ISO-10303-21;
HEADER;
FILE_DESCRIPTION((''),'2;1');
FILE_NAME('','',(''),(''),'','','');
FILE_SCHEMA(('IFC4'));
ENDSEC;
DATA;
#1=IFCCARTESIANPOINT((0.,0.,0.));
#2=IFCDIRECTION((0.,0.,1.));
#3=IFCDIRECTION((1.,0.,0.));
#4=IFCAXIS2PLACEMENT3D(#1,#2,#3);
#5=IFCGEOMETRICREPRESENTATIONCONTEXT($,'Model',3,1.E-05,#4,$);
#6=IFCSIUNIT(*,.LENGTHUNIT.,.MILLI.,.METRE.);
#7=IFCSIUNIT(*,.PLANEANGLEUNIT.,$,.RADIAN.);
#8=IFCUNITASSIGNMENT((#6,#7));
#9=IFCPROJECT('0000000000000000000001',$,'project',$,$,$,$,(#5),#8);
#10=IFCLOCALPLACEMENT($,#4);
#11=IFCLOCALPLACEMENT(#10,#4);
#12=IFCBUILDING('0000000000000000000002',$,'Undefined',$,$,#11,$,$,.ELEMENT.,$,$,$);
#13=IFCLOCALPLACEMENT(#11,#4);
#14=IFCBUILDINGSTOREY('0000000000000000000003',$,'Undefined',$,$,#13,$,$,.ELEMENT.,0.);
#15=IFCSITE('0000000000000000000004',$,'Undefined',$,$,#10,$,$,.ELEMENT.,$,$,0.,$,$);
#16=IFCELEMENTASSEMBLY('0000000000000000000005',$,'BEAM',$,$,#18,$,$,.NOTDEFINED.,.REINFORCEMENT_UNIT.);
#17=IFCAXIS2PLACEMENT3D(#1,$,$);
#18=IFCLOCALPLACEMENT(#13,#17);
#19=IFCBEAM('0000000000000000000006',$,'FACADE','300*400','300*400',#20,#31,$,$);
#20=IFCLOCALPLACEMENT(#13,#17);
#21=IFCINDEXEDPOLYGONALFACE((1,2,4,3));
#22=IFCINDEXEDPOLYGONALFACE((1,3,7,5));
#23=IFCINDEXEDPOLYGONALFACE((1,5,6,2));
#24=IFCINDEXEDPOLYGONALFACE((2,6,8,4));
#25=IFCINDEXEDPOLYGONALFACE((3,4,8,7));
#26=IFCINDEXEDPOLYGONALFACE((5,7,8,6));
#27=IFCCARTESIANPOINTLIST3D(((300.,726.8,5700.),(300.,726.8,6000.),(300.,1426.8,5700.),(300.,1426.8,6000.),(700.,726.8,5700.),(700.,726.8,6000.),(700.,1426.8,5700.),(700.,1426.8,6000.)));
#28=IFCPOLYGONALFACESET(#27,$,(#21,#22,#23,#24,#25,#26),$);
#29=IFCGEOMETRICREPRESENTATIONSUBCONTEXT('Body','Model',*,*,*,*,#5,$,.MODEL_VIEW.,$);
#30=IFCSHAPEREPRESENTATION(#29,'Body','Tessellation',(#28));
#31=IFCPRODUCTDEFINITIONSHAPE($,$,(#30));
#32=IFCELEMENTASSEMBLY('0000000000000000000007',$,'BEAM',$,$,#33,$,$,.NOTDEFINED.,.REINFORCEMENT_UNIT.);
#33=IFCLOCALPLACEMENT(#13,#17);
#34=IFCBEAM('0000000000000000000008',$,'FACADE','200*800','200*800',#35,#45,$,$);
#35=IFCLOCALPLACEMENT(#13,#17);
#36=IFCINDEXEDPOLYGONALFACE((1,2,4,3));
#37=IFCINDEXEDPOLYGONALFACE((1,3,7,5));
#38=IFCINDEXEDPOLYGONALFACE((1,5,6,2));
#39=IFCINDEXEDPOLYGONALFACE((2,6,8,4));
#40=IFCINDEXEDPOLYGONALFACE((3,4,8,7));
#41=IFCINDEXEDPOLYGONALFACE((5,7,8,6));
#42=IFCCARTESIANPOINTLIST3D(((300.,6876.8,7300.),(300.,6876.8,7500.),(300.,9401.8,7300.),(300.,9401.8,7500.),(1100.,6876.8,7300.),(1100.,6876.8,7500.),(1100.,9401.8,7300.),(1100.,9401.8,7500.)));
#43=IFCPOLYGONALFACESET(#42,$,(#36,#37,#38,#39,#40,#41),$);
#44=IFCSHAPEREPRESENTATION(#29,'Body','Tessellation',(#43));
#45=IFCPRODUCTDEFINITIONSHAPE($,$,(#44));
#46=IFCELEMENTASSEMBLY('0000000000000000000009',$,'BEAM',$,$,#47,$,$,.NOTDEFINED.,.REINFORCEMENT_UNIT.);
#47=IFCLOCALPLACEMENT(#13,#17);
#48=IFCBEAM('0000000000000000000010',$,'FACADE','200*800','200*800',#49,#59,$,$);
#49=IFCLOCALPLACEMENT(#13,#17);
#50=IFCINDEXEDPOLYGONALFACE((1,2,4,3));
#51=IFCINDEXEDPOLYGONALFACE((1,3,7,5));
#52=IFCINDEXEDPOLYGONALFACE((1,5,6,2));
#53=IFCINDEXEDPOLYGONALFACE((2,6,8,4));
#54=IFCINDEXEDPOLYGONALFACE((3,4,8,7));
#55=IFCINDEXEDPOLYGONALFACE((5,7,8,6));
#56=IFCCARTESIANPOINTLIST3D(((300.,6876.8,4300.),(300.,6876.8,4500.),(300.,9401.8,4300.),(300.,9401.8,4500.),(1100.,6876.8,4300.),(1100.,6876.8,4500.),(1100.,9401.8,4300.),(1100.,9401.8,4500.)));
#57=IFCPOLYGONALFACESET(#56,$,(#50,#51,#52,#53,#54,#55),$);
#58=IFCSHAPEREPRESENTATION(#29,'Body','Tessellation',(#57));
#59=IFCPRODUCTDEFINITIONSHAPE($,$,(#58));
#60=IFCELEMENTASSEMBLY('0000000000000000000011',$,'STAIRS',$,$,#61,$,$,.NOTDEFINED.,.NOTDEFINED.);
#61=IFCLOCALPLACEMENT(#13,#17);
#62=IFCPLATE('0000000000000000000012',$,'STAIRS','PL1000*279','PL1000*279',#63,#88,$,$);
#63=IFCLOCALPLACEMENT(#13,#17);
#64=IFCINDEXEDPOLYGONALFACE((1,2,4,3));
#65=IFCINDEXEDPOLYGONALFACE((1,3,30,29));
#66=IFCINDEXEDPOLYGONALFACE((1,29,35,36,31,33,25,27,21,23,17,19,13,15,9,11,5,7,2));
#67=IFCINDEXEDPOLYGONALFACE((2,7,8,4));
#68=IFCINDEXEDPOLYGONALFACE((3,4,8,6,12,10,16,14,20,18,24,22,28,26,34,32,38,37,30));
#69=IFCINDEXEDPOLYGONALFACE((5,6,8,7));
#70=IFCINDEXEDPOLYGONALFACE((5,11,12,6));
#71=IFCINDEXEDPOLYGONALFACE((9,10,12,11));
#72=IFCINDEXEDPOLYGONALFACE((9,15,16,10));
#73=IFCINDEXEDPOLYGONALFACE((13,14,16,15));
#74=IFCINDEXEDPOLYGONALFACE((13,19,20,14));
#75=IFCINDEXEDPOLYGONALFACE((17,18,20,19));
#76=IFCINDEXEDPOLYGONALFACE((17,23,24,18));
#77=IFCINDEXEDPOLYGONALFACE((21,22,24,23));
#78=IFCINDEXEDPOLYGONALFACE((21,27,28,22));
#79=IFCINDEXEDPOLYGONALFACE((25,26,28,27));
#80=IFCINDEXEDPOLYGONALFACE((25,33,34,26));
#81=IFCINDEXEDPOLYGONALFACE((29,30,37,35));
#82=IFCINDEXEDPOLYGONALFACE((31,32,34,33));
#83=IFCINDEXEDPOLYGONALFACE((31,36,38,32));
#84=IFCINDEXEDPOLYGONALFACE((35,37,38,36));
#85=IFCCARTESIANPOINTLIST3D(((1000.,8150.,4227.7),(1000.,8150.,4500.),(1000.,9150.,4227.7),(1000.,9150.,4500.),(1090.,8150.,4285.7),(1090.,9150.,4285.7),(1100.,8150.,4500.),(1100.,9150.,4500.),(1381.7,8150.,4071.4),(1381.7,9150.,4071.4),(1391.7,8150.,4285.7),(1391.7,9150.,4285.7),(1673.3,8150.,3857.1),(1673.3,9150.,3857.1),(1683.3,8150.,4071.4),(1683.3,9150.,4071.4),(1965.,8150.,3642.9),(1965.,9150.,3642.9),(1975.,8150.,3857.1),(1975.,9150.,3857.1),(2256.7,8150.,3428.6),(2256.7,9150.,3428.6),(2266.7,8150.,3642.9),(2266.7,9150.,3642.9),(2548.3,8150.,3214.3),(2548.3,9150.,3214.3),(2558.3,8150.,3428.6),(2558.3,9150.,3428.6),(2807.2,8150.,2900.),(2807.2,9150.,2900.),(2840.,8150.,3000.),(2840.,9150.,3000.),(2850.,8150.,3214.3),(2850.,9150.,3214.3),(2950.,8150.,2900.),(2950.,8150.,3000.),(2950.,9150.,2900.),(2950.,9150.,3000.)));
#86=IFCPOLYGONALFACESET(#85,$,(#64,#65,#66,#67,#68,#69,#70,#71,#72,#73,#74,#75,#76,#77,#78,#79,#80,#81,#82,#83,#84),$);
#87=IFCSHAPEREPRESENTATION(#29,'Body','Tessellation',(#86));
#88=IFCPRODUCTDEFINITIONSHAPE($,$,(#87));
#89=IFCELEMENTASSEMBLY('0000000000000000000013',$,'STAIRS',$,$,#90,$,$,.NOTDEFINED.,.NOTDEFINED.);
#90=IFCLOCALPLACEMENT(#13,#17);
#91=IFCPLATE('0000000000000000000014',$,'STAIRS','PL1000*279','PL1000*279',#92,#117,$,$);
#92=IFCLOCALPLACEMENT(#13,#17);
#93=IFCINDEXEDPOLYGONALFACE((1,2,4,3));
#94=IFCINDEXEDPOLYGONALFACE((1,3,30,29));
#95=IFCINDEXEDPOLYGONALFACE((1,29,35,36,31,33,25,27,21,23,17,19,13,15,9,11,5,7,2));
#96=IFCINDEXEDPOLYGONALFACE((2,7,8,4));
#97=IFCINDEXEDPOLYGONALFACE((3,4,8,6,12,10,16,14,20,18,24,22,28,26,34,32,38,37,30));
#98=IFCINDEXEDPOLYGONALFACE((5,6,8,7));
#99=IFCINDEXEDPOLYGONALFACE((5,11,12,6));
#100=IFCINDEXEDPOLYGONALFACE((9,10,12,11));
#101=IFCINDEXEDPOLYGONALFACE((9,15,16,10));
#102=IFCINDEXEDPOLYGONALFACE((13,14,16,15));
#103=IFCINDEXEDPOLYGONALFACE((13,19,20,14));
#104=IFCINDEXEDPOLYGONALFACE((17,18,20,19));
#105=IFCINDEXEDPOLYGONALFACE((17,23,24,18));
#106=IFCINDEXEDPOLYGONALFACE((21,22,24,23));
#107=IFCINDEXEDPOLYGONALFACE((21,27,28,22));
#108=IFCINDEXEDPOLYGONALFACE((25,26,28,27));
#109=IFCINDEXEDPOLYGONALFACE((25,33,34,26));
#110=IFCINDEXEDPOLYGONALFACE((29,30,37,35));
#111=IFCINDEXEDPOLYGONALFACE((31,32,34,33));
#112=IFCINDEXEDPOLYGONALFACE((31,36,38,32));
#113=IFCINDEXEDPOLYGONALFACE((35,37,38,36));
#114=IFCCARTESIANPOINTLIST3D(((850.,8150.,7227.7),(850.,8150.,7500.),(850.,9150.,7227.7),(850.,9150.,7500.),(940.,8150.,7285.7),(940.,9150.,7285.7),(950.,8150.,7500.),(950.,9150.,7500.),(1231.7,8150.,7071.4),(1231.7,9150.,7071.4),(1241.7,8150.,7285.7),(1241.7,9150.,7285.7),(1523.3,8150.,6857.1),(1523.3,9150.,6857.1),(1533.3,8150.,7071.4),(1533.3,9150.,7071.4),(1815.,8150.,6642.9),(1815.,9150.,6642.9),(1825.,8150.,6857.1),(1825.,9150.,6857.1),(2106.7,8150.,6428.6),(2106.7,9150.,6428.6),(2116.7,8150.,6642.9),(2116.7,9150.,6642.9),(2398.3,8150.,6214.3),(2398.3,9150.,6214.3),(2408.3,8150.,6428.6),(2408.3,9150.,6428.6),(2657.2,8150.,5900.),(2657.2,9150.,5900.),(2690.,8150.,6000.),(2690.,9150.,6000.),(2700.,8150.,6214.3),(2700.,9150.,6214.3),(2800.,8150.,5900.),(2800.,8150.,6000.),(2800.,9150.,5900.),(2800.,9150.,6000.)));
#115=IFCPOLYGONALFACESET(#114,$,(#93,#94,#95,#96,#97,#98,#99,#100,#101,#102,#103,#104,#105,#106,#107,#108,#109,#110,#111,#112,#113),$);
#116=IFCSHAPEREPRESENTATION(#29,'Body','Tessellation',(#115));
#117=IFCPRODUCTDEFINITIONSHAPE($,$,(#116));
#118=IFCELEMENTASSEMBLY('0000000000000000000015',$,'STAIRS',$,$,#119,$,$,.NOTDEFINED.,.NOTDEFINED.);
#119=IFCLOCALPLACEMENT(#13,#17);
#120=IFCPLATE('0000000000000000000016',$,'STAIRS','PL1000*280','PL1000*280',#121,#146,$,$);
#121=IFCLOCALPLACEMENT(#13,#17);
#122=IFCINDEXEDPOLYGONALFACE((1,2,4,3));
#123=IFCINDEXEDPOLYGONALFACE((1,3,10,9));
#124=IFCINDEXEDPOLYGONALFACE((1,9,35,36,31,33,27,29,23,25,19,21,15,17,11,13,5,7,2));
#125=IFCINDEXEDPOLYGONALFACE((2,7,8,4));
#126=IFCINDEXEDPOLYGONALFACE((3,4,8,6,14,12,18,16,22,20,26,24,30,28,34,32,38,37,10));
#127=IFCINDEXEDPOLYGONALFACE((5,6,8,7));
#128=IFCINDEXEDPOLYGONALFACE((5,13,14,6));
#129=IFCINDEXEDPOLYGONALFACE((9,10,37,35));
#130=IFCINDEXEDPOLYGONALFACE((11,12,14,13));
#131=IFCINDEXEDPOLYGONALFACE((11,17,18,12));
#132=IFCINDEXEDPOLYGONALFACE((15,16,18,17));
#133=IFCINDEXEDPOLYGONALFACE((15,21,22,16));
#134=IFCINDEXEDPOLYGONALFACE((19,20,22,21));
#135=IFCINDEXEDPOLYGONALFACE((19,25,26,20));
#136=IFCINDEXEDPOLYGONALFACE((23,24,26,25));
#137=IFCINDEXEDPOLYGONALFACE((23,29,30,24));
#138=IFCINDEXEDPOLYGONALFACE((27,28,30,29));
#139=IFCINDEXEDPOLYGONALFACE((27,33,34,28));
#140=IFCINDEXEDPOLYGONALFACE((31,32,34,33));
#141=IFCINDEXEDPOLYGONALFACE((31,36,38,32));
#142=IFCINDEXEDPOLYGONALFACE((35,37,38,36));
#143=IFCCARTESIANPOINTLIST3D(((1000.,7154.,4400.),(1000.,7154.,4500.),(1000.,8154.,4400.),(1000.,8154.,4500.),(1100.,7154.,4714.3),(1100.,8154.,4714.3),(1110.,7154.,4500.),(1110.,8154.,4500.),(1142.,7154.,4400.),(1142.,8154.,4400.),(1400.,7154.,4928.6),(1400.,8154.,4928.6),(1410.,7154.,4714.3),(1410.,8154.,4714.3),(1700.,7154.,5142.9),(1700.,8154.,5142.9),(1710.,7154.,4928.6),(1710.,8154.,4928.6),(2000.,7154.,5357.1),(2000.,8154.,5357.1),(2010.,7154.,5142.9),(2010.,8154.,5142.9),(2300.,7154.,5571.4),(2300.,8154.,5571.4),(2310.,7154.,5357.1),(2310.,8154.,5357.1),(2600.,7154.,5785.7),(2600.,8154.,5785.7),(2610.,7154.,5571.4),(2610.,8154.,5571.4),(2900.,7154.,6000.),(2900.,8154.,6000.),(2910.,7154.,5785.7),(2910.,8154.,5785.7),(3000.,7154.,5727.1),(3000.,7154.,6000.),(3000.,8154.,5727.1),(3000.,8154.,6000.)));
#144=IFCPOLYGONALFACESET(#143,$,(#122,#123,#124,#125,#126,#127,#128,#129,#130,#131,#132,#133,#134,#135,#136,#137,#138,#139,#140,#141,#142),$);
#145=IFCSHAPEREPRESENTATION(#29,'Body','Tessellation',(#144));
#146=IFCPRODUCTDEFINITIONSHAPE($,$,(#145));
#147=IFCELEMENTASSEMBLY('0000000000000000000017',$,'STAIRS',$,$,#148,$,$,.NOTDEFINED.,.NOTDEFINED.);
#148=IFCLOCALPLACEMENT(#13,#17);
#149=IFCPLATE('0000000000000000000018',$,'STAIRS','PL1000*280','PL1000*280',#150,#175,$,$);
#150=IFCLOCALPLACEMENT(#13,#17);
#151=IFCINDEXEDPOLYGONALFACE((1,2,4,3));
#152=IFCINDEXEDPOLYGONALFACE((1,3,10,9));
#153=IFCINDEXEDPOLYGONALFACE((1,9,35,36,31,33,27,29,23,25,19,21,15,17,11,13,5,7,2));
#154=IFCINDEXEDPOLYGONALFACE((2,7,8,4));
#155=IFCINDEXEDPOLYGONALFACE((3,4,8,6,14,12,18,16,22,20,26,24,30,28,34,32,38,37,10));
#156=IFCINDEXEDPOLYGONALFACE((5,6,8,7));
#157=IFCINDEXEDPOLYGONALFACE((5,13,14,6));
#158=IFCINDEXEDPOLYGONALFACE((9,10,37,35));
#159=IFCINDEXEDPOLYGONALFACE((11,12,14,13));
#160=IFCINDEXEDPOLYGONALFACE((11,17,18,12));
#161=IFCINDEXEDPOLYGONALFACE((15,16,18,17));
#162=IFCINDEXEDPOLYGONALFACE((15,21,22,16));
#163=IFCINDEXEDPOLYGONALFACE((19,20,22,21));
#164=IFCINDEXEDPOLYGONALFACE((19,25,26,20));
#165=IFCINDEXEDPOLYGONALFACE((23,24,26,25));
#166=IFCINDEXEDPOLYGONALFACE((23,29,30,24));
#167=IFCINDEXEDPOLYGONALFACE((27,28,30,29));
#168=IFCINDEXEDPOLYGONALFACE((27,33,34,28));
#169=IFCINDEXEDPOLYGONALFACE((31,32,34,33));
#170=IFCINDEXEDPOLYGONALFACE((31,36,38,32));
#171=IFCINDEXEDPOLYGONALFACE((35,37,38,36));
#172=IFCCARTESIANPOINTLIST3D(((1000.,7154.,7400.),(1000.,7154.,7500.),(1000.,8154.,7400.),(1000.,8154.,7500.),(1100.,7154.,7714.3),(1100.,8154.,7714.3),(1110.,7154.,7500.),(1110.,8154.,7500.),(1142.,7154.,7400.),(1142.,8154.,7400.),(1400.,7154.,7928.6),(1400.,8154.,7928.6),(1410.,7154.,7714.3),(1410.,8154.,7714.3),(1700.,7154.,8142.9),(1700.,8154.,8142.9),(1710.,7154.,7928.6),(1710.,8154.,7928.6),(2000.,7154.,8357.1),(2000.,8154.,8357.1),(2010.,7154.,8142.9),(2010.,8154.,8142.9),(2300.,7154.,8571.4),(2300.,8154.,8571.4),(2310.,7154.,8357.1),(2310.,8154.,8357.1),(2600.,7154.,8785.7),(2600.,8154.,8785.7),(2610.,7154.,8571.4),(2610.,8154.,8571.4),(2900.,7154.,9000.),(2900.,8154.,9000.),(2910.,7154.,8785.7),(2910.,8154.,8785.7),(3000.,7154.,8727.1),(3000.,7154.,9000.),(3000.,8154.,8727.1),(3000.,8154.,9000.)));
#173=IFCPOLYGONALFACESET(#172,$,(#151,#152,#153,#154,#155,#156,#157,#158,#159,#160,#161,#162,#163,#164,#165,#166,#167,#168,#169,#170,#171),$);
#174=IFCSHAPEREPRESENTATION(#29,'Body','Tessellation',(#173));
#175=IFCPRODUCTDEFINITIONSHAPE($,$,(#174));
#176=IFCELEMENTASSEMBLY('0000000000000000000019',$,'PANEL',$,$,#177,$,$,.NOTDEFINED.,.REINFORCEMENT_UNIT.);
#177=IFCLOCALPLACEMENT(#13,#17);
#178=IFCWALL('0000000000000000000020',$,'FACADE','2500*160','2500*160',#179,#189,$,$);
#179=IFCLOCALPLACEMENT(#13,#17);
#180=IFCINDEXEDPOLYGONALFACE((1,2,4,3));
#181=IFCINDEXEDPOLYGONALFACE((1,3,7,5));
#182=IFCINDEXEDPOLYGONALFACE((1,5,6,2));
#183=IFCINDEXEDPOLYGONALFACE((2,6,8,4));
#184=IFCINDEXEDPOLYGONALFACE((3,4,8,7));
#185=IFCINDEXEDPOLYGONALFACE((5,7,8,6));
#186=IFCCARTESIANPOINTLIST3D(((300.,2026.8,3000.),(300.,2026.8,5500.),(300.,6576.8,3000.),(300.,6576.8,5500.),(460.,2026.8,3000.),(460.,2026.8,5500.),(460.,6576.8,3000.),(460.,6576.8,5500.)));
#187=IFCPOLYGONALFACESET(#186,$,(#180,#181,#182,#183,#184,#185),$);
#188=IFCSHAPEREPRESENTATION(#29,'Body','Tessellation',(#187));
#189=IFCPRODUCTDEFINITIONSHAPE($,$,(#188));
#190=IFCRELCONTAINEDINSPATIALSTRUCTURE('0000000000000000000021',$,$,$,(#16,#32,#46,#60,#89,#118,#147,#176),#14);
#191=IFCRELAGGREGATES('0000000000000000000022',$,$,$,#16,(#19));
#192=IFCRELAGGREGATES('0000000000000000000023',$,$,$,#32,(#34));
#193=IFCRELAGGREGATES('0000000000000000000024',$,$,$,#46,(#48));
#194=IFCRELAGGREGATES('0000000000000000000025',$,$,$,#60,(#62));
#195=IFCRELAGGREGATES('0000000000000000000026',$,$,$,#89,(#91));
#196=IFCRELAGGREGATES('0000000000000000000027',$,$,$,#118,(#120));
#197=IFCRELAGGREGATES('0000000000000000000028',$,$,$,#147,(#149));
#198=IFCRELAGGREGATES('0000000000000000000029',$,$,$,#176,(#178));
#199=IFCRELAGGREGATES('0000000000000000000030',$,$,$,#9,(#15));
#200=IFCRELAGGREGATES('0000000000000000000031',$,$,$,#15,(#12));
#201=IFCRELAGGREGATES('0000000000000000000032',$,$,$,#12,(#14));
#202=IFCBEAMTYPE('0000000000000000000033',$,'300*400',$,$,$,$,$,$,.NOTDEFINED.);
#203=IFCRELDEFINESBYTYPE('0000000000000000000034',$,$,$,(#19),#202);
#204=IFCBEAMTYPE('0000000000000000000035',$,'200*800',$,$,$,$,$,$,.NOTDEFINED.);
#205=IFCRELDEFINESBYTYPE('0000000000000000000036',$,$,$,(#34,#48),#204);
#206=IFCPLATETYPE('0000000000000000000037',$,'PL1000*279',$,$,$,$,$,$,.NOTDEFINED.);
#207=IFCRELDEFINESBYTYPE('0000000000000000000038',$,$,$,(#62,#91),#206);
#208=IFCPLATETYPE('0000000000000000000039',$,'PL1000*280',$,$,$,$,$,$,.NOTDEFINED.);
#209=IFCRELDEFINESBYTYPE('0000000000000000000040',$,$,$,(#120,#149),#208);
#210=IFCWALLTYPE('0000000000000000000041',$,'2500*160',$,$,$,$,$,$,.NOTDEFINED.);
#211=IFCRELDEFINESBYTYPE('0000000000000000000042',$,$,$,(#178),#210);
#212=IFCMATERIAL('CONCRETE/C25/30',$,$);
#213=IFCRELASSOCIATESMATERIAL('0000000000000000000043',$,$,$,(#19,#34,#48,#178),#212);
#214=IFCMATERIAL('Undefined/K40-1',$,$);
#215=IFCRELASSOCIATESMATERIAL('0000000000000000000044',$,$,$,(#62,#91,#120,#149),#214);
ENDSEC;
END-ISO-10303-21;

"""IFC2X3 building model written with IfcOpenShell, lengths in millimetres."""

from ifc_helpers import new_model, si_unit, frame, frame_2d, origin_with_axes, origin_2d_with_axis, place, context, subcontext, project, spatial, polyline, rectangle, outline, extrude, material, type_object, element, aggregate, save


model = new_model("IFC2X3")

# Units and contexts
model_context = context("Model", 3, precision=1e-05, world=origin_with_axes())
body_context = subcontext(model_context, "Body", "Model", "MODEL_VIEW")
ifc_project = project(units=[si_unit("LENGTHUNIT", "METRE", prefix="MILLI"), si_unit("PLANEANGLEUNIT", "RADIAN")], contexts=[model_context])

# Site, building, storey
site_placement = place(None, origin_with_axes())
site = spatial("IfcSite", under=ifc_project, at=site_placement, Name="Undefined", CompositionType="ELEMENT", RefElevation=0.0)
building_placement = place(site_placement, origin_with_axes())
building = spatial("IfcBuilding", under=site, at=building_placement, Name="Undefined", CompositionType="ELEMENT")
storey_placement = place(building_placement, origin_with_axes())
storey = spatial("IfcBuildingStorey", under=building, at=storey_placement, Name="Undefined", CompositionType="ELEMENT", Elevation=0.0)

# Shared definitions
ifc_material_1 = material(Name="CONCRETE/C25/30")

# Element assemblies, beams
beam_type_1 = type_object("IfcBeamType", Name="300*400", PredefinedType="NOTDEFINED")
assembly_1_placement = place(storey_placement, origin_with_axes())
assembly_1 = element("IfcElementAssembly", 1, at=assembly_1_placement, inside=storey, Name="BEAM", AssemblyPlace="NOTDEFINED", PredefinedType="REINFORCEMENT_UNIT")
beam_1_placement = place(assembly_1_placement, frame((500.0, 1426.8, 5850.0), z_axis=(0.0, 0.0, 1.0), x_axis=(0.0, -1.0, 0.0)))
beam_1 = element("IfcBeam", 2, at=beam_1_placement, type_object=beam_type_1, material=ifc_material_1, Name="FACADE", Description="300*400", ObjectType="300*400", context=body_context, shape_type="SweptSolid", body=[
    extrude(rectangle(XDim=400.0, YDim=300.0, at=origin_2d_with_axis()), frame((700.0, 0.0, 0.0), z_axis=(-1.0, 0.0, 0.0), x_axis=(0.0, -1.0, 0.0)), (0.0, 0.0, 1.0), 700.0),
])
aggregate(assembly_1, [beam_1])
assembly_2_placement = place(storey_placement, origin_with_axes())
assembly_2 = element("IfcElementAssembly", 3, at=assembly_2_placement, inside=storey, Name="BEAM", AssemblyPlace="NOTDEFINED", PredefinedType="REINFORCEMENT_UNIT")
beam_type_2 = type_object("IfcBeamType", Name="200*800", PredefinedType="NOTDEFINED")
beam_2_placement = place(assembly_2_placement, frame((700.0, 9401.8, 7400.0), z_axis=(0.0, 0.0, 1.0), x_axis=(0.0, -1.0, 0.0)))
beam_2 = element("IfcBeam", 4, at=beam_2_placement, type_object=beam_type_2, material=ifc_material_1, Name="FACADE", Description="200*800", ObjectType="200*800", context=body_context, shape_type="SweptSolid", body=[
    extrude(rectangle(XDim=800.0, YDim=200.0, at=origin_2d_with_axis()), frame((2525.0, 0.0, 0.0), z_axis=(-1.0, 0.0, 0.0), x_axis=(0.0, -1.0, 0.0)), (0.0, 0.0, 1.0), 2525.0),
])
aggregate(assembly_2, [beam_2])
assembly_3_placement = place(storey_placement, origin_with_axes())
assembly_3 = element("IfcElementAssembly", 5, at=assembly_3_placement, inside=storey, Name="BEAM", AssemblyPlace="NOTDEFINED", PredefinedType="REINFORCEMENT_UNIT")
beam_3_placement = place(assembly_3_placement, frame((700.0, 9401.8, 4400.0), z_axis=(0.0, 0.0, 1.0), x_axis=(0.0, -1.0, 0.0)))
beam_3 = element("IfcBeam", 6, at=beam_3_placement, type_object=beam_type_2, material=ifc_material_1, Name="FACADE", Description="200*800", ObjectType="200*800", context=body_context, shape_type="SweptSolid", body=[
    extrude(rectangle(XDim=800.0, YDim=200.0, at=origin_2d_with_axis()), frame((2525.0, 0.0, 0.0), z_axis=(-1.0, 0.0, 0.0), x_axis=(0.0, -1.0, 0.0)), (0.0, 0.0, 1.0), 2525.0),
])
aggregate(assembly_3, [beam_3])

# Element assemblies, plates
assembly_4_placement = place(storey_placement, origin_with_axes())
assembly_4 = element("IfcElementAssembly", 7, at=assembly_4_placement, inside=storey, Name="STAIRS", AssemblyPlace="NOTDEFINED", PredefinedType="NOTDEFINED")
ifc_material_2 = material(Name="Undefined/K40-1")
plate_type_1 = type_object("IfcPlateType", Name="PL1000*279", PredefinedType="NOTDEFINED")
plate_1_placement = place(assembly_4_placement, frame((2840.0, 8650.0, 3000.0), z_axis=(0.0, 1.0, 0.0), x_axis=(1.0, 0.0, 0.0)))
plate_1 = element("IfcPlate", 8, at=plate_1_placement, type_object=plate_type_1, material=ifc_material_2, Name="STAIRS", Description="PL1000*279", ObjectType="PL1000*279", context=body_context, shape_type="SweptSolid", body=[
    extrude(outline(polyline([(0.0, 0.0), (110.0, 0.0), (110.0, 100.0), (-32.8, 100.0), (-1840.0, -1227.7), (-1840.0, -1500.0), (-1740.0, -1500.0), (-1750.0, -1285.7), (-1448.3, -1285.7), (-1458.3, -1071.4), (-1156.7, -1071.4), (-1166.7, -857.1), (-865.0, -857.1), (-875.0, -642.9), (-573.3, -642.9), (-583.3, -428.6), (-281.7, -428.6), (-291.7, -214.3), (10.0, -214.3), (0.0, 0.0), (0.0, 0.0)])), frame((0.0, 0.0, -500.0), z_axis=(0.0, 0.0, 1.0), x_axis=(1.0, 0.0, 0.0)), (0.0, 0.0, 1.0), 1000.0),
])
aggregate(assembly_4, [plate_1])
assembly_5_placement = place(storey_placement, origin_with_axes())
assembly_5 = element("IfcElementAssembly", 9, at=assembly_5_placement, inside=storey, Name="STAIRS", AssemblyPlace="NOTDEFINED", PredefinedType="NOTDEFINED")
plate_2_placement = place(assembly_5_placement, frame((2690.0, 8650.0, 6000.0), z_axis=(0.0, 1.0, 0.0), x_axis=(1.0, 0.0, 0.0)))
plate_2 = element("IfcPlate", 10, at=plate_2_placement, type_object=plate_type_1, material=ifc_material_2, Name="STAIRS", Description="PL1000*279", ObjectType="PL1000*279", context=body_context, shape_type="SweptSolid", body=[
    extrude(outline(polyline([(0.0, 0.0), (110.0, 0.0), (110.0, 100.0), (-32.8, 100.0), (-1840.0, -1227.7), (-1840.0, -1500.0), (-1740.0, -1500.0), (-1750.0, -1285.7), (-1448.3, -1285.7), (-1458.3, -1071.4), (-1156.7, -1071.4), (-1166.7, -857.1), (-865.0, -857.1), (-875.0, -642.9), (-573.3, -642.9), (-583.3, -428.6), (-281.7, -428.6), (-291.7, -214.3), (10.0, -214.3), (0.0, 0.0), (0.0, 0.0)])), frame((0.0, 0.0, -500.0), z_axis=(0.0, 0.0, 1.0), x_axis=(1.0, 0.0, 0.0)), (0.0, 0.0, 1.0), 1000.0),
])
aggregate(assembly_5, [plate_2])
assembly_6_placement = place(storey_placement, origin_with_axes())
assembly_6 = element("IfcElementAssembly", 11, at=assembly_6_placement, inside=storey, Name="STAIRS", AssemblyPlace="NOTDEFINED", PredefinedType="NOTDEFINED")
plate_type_2 = type_object("IfcPlateType", Name="PL1000*280", PredefinedType="NOTDEFINED")
plate_3_placement = place(assembly_6_placement, frame((1110.0, 7654.0, 4500.0), z_axis=(0.0, -1.0, 0.0), x_axis=(-1.0, 0.0, 0.0)))
plate_3 = element("IfcPlate", 12, at=plate_3_placement, type_object=plate_type_2, material=ifc_material_2, Name="STAIRS", Description="PL1000*280", ObjectType="PL1000*280", context=body_context, shape_type="SweptSolid", body=[
    extrude(outline(polyline([(0.0, 0.0), (110.0, 0.0), (110.0, 100.0), (-32.0, 100.0), (-1890.0, -1227.1), (-1890.0, -1500.0), (-1790.0, -1500.0), (-1800.0, -1285.7), (-1490.0, -1285.7), (-1500.0, -1071.4), (-1190.0, -1071.4), (-1200.0, -857.1), (-890.0, -857.1), (-900.0, -642.9), (-590.0, -642.9), (-600.0, -428.6), (-290.0, -428.6), (-300.0, -214.3), (10.0, -214.3), (0.0, 0.0), (0.0, 0.0)])), frame((0.0, 0.0, -500.0), z_axis=(0.0, 0.0, 1.0), x_axis=(1.0, 0.0, 0.0)), (0.0, 0.0, 1.0), 1000.0),
])
aggregate(assembly_6, [plate_3])
assembly_7_placement = place(storey_placement, origin_with_axes())
assembly_7 = element("IfcElementAssembly", 13, at=assembly_7_placement, inside=storey, Name="STAIRS", AssemblyPlace="NOTDEFINED", PredefinedType="NOTDEFINED")
plate_4_placement = place(assembly_7_placement, frame((1110.0, 7654.0, 7500.0), z_axis=(0.0, -1.0, 0.0), x_axis=(-1.0, 0.0, 0.0)))
plate_4 = element("IfcPlate", 14, at=plate_4_placement, type_object=plate_type_2, material=ifc_material_2, Name="STAIRS", Description="PL1000*280", ObjectType="PL1000*280", context=body_context, shape_type="SweptSolid", body=[
    extrude(outline(polyline([(0.0, 0.0), (110.0, 0.0), (110.0, 100.0), (-32.0, 100.0), (-1890.0, -1227.1), (-1890.0, -1500.0), (-1790.0, -1500.0), (-1800.0, -1285.7), (-1490.0, -1285.7), (-1500.0, -1071.4), (-1190.0, -1071.4), (-1200.0, -857.1), (-890.0, -857.1), (-900.0, -642.9), (-590.0, -642.9), (-600.0, -428.6), (-290.0, -428.6), (-300.0, -214.3), (10.0, -214.3), (0.0, 0.0), (0.0, 0.0)])), frame((0.0, 0.0, -500.0), z_axis=(0.0, 0.0, 1.0), x_axis=(1.0, 0.0, 0.0)), (0.0, 0.0, 1.0), 1000.0),
])
aggregate(assembly_7, [plate_4])

# Element assembly, wall
assembly_8_placement = place(storey_placement, origin_with_axes())
assembly_8 = element("IfcElementAssembly", 15, at=assembly_8_placement, inside=storey, Name="PANEL", AssemblyPlace="NOTDEFINED", PredefinedType="REINFORCEMENT_UNIT")
wall_type = type_object("IfcWallType", Name="2500*160", PredefinedType="NOTDEFINED")
wall_1_placement = place(assembly_8_placement, frame((380.0, 6576.8, 3000.0), z_axis=(0.0, 0.0, 1.0), x_axis=(0.0, -1.0, 0.0)))
wall_1 = element("IfcWall", 16, at=wall_1_placement, type_object=wall_type, material=ifc_material_1, Name="FACADE", Description="2500*160", ObjectType="2500*160", context=body_context, shape_type="SweptSolid", body=[
    extrude(rectangle(XDim=4550.0, YDim=160.0, at=frame_2d((0.0, 2275.0), x_axis=(0.0, -1.0))), frame((0.0, 0.0, 0.0), z_axis=(0.0, 0.0, 1.0), x_axis=(0.0, -1.0, 0.0)), (0.0, 0.0, 1.0), 2500.0),
])
aggregate(assembly_8, [wall_1])

save(model, "model.ifc")
